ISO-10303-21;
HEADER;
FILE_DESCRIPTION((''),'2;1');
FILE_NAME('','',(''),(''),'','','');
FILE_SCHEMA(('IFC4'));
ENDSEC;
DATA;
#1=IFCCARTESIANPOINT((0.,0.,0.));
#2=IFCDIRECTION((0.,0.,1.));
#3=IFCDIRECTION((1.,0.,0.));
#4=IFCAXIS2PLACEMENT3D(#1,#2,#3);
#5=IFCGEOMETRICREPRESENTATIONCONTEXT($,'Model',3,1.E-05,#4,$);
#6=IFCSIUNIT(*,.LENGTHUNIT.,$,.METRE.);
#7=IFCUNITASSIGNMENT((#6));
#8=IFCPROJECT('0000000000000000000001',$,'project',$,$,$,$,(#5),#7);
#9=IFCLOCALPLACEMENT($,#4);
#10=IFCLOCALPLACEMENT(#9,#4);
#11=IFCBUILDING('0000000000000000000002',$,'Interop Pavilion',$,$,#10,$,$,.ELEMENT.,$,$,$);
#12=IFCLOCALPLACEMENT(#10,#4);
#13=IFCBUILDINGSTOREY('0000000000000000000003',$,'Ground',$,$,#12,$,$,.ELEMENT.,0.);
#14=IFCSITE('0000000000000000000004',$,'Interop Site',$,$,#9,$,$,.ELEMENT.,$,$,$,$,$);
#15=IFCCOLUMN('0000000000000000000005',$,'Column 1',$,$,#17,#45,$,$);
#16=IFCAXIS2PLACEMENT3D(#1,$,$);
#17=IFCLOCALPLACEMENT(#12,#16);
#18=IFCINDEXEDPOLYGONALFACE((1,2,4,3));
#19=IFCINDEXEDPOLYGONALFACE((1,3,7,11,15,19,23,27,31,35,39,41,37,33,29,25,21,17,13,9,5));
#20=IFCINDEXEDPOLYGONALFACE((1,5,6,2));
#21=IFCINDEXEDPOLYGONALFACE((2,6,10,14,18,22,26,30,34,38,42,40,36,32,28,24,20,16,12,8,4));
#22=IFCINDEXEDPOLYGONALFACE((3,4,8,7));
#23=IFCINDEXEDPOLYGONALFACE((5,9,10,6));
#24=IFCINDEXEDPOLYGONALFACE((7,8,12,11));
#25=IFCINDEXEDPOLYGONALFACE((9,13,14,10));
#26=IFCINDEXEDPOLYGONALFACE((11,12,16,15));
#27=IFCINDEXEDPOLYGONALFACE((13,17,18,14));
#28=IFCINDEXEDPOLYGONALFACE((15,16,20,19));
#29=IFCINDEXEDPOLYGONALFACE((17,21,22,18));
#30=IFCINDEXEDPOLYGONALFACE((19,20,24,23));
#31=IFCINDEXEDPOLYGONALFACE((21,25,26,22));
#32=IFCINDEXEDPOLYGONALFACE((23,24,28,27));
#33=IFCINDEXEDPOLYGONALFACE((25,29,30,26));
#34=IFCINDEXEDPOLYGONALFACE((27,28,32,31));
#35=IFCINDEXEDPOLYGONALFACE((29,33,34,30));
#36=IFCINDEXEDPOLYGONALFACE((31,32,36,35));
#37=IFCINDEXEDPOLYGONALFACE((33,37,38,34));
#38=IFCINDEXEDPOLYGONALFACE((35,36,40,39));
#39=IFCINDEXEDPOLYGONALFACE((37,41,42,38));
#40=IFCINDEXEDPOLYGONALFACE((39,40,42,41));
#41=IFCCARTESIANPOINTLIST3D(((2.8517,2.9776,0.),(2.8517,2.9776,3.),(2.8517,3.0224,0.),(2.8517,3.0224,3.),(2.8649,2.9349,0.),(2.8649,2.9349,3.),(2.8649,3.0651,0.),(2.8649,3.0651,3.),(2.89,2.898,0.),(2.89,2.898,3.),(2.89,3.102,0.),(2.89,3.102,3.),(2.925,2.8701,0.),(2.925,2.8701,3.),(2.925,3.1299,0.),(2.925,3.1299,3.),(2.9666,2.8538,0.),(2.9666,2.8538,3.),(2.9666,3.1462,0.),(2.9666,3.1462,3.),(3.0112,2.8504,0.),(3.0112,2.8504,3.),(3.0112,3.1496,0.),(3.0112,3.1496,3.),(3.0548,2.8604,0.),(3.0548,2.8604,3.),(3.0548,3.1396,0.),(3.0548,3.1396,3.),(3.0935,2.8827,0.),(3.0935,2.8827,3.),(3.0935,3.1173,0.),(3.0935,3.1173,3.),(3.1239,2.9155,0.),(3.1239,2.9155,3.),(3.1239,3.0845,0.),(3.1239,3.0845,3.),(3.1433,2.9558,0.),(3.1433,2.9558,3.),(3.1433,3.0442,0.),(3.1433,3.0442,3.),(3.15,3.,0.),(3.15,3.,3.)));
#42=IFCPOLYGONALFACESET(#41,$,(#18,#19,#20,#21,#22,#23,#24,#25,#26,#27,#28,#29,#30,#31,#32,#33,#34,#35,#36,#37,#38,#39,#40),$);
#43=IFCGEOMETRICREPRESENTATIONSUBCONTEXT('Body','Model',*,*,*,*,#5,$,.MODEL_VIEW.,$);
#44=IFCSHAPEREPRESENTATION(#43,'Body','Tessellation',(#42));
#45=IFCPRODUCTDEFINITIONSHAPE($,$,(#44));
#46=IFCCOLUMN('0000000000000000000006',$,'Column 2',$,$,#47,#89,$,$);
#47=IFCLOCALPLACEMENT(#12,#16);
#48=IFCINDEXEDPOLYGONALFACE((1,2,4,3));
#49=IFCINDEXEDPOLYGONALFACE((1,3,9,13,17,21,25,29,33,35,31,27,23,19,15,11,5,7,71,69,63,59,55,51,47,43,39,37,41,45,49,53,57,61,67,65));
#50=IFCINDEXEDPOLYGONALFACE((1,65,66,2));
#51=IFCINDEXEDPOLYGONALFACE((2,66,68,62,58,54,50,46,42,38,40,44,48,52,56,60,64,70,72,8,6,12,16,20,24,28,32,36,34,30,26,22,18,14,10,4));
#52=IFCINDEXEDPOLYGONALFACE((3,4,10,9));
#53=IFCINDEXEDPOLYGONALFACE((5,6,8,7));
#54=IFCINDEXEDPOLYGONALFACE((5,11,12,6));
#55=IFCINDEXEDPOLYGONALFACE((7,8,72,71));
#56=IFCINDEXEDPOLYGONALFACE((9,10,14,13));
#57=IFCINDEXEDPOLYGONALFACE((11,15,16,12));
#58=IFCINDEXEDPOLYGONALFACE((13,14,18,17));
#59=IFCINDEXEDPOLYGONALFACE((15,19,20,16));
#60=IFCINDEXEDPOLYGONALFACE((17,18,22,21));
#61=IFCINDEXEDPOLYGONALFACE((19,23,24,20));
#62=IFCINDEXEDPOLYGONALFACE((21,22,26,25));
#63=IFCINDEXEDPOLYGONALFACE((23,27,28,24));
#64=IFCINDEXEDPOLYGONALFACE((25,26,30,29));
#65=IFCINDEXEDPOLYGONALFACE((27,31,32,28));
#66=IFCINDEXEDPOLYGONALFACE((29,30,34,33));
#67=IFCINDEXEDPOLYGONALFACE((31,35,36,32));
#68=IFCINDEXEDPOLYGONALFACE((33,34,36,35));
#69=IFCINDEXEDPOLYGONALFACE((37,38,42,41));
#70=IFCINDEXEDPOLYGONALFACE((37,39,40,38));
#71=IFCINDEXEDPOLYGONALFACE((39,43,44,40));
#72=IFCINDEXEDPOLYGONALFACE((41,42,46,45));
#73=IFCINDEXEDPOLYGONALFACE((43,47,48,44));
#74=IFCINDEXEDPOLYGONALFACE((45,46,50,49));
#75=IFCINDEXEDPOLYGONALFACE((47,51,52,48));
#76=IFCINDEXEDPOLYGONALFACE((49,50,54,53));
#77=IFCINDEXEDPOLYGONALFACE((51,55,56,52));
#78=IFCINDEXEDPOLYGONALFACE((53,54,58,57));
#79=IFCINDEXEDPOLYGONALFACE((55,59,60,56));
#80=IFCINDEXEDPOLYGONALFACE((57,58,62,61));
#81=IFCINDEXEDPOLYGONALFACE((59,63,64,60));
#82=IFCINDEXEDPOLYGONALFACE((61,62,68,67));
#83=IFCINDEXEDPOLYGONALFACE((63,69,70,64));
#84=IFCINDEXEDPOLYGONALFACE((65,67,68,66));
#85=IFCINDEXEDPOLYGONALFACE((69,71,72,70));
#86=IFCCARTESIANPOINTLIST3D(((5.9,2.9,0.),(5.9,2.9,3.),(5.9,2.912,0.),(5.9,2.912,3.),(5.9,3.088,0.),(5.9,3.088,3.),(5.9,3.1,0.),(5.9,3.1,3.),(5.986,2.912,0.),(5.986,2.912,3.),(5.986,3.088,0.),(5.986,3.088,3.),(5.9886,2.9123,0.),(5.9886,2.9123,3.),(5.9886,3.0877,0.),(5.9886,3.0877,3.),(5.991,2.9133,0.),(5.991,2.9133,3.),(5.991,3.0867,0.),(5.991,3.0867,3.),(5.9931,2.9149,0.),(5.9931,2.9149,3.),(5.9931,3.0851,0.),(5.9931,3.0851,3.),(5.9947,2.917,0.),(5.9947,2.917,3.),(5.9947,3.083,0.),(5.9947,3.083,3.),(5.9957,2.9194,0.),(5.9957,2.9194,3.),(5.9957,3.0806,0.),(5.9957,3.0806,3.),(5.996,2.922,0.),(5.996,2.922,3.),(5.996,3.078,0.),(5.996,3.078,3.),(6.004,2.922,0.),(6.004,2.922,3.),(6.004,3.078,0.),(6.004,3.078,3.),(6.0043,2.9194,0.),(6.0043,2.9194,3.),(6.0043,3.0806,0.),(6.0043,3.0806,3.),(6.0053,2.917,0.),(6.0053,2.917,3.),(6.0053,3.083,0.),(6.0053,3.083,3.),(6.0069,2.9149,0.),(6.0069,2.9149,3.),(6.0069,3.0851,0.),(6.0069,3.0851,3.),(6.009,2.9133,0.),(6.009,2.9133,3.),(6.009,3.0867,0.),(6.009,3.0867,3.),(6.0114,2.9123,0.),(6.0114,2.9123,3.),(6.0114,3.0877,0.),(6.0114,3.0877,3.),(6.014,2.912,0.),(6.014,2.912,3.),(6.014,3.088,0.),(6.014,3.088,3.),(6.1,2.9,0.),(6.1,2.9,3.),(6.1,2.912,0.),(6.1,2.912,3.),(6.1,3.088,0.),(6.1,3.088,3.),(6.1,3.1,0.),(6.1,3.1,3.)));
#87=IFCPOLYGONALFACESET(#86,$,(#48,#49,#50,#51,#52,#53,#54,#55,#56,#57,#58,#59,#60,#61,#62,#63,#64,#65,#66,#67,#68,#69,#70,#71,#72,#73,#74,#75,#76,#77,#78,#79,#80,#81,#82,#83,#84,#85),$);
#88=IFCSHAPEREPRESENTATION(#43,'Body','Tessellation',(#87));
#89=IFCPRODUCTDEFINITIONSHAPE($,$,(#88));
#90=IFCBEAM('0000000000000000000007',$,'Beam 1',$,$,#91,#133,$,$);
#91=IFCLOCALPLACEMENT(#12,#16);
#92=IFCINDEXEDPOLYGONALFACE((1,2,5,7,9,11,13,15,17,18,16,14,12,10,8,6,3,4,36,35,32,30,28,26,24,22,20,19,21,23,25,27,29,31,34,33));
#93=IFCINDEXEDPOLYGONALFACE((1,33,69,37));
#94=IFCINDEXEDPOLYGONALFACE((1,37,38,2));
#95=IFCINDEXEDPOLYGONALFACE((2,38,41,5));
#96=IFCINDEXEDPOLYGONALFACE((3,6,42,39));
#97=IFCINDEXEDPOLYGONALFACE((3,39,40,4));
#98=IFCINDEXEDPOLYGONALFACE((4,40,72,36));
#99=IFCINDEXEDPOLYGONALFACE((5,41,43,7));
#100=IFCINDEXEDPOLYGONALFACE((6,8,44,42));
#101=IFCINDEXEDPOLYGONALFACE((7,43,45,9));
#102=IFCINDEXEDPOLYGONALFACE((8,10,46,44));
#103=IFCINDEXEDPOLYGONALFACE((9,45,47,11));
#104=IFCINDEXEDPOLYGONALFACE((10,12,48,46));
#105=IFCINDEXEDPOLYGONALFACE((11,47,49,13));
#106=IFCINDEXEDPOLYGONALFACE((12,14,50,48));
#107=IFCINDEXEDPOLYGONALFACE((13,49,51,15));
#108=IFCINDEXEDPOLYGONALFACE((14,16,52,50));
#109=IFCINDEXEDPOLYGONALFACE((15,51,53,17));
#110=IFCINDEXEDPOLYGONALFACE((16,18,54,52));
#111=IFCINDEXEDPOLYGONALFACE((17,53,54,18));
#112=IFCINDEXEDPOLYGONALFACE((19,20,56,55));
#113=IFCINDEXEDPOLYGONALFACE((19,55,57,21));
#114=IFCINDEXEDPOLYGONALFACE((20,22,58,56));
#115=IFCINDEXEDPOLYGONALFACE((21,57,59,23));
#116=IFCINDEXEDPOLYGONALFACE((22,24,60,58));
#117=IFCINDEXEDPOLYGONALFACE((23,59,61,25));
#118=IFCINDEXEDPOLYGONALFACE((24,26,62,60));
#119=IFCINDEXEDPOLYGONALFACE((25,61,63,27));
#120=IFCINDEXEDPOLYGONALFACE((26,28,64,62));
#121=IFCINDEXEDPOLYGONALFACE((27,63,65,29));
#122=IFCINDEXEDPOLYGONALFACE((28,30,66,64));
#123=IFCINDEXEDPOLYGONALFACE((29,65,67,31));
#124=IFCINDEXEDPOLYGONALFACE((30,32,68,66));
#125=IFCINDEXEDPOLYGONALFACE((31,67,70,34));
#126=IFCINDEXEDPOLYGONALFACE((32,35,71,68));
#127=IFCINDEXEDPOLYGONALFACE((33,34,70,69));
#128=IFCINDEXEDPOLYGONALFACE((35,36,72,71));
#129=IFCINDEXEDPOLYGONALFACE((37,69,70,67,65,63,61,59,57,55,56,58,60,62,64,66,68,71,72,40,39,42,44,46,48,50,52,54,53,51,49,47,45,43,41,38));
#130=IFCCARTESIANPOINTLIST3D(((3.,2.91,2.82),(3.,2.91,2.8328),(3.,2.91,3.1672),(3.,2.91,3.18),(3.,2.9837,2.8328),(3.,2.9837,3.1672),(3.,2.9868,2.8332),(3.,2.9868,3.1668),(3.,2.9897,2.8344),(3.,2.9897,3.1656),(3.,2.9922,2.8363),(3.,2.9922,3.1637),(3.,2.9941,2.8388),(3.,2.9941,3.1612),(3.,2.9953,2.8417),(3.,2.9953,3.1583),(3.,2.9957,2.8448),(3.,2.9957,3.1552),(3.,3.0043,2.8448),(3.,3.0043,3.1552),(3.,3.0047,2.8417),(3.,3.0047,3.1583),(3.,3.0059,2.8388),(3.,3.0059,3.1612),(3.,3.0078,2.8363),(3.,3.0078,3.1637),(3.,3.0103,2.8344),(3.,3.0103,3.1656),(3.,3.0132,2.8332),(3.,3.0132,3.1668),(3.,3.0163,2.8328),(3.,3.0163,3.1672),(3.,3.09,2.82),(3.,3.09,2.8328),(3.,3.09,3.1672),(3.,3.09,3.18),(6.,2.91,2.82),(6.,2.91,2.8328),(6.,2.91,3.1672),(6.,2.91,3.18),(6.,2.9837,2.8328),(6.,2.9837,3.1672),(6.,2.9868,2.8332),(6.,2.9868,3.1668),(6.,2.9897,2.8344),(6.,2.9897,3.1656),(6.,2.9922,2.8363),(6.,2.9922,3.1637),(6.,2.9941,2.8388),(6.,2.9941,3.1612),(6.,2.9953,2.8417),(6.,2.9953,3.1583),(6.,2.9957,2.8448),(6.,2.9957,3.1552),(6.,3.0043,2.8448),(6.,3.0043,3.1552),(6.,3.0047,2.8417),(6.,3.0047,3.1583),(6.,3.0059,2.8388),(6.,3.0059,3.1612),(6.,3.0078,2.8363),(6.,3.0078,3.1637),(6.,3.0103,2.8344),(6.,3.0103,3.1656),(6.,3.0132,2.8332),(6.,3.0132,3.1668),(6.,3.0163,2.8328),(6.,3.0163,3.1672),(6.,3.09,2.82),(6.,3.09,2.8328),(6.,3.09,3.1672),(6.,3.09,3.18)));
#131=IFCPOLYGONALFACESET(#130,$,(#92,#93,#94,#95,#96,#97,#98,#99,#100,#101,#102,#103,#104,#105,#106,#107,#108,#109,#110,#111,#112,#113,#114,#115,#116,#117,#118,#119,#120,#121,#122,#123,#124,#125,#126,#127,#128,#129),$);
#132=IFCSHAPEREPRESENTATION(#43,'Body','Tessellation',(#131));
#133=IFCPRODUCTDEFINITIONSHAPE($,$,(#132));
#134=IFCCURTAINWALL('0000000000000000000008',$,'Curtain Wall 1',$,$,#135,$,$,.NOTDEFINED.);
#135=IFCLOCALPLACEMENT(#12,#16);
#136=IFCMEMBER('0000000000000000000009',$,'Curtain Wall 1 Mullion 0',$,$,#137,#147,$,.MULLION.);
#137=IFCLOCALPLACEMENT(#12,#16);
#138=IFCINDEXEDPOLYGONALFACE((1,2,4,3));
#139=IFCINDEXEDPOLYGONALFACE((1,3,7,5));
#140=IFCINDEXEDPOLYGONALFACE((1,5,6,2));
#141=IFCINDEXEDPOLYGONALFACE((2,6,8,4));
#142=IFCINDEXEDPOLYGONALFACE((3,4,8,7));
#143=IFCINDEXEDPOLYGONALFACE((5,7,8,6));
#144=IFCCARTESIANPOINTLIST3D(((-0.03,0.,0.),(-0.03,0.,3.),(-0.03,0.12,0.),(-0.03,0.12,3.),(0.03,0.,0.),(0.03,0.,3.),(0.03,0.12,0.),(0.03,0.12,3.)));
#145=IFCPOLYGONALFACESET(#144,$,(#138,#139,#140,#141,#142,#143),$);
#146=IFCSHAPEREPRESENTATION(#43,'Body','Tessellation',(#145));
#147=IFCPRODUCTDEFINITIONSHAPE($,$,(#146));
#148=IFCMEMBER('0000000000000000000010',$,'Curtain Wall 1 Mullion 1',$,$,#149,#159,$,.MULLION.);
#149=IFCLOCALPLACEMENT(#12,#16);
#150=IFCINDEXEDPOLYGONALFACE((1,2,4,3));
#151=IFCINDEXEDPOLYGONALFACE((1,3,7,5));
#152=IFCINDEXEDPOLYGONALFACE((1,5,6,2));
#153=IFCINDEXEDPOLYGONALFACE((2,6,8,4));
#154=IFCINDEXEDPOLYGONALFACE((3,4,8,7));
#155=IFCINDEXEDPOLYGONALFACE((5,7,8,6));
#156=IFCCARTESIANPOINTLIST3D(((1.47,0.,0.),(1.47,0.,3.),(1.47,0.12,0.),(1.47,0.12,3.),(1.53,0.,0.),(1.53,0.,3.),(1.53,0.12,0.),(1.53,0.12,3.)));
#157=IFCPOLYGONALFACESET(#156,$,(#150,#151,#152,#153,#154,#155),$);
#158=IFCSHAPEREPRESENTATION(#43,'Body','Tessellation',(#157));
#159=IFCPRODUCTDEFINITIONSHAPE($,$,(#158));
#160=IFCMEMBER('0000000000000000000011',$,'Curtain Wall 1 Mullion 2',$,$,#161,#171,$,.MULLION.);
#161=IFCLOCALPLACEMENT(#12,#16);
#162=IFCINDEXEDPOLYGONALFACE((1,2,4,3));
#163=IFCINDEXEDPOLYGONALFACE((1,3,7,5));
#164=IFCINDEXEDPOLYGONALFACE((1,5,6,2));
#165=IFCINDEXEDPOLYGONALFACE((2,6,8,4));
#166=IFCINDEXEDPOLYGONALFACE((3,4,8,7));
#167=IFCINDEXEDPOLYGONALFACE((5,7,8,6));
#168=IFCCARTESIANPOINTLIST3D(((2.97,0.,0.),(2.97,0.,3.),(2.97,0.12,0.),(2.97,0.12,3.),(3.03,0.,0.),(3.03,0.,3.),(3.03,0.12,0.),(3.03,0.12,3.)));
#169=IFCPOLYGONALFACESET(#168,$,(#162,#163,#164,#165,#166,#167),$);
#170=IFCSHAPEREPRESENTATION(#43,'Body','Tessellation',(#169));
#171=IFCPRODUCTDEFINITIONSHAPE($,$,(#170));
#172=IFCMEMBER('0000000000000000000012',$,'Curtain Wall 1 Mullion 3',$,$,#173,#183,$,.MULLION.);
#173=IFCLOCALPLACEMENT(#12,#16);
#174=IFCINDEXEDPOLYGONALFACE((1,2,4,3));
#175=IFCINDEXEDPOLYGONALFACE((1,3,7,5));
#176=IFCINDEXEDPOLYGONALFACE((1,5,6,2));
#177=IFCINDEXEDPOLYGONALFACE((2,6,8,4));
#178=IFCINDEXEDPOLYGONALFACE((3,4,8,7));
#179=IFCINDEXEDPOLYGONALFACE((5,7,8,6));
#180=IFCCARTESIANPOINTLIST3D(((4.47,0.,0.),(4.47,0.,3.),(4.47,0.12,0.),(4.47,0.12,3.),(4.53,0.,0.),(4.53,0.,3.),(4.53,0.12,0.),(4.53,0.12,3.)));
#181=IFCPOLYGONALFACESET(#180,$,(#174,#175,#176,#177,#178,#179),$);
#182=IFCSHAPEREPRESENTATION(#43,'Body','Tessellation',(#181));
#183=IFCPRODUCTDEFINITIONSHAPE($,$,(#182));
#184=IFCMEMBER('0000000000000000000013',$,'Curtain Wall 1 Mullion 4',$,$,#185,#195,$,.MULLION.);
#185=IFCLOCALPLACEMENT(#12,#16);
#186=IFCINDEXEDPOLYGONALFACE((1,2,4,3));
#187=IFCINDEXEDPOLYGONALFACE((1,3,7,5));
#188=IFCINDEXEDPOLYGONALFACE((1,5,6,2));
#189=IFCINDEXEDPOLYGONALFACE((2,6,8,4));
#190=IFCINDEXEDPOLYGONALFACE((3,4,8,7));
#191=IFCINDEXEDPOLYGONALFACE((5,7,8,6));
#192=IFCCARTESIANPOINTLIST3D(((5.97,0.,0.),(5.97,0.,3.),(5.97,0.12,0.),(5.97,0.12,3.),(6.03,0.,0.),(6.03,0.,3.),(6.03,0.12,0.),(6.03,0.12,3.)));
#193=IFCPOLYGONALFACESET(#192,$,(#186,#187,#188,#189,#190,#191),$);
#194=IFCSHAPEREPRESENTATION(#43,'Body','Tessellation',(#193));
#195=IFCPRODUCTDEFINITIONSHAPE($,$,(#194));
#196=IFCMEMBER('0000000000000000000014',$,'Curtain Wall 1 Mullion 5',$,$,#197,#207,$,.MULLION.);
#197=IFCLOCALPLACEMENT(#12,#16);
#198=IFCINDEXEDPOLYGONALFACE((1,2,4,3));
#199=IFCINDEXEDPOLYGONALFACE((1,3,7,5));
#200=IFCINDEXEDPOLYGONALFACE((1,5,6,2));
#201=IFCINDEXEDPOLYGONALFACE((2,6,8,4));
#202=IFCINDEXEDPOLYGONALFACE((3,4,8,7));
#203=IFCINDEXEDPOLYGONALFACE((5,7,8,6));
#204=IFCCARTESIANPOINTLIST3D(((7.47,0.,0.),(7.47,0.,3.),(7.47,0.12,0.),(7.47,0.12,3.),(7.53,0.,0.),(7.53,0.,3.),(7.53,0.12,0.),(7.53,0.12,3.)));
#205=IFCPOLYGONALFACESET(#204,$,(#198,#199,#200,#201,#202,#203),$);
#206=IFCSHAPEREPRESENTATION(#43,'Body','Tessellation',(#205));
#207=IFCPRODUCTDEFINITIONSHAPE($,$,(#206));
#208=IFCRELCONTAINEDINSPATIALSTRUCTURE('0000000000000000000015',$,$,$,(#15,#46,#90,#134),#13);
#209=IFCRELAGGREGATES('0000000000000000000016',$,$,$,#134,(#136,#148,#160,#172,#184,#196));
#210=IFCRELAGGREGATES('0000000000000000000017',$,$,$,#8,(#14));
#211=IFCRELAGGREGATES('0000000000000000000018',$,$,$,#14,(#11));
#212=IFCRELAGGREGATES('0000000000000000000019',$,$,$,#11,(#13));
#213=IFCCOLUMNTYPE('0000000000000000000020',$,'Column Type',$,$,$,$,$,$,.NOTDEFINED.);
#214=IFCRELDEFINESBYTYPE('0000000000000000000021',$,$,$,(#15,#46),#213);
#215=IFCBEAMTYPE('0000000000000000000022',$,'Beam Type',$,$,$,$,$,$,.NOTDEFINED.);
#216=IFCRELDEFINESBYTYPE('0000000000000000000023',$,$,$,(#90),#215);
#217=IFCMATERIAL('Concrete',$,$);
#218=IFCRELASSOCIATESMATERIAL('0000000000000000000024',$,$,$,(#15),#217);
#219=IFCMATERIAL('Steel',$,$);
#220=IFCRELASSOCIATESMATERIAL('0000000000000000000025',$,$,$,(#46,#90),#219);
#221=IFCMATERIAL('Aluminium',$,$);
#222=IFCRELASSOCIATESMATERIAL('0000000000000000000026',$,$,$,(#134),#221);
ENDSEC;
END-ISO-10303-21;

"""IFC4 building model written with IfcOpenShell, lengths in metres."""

from ifc_helpers import new_model, si_unit, frame, frame_2d, origin_with_axes, origin_2d, place, context, subcontext, project, spatial, rectangle, circle, i_section, extrude, material, type_object, element, aggregate, save


model = new_model("IFC4")

# Units and contexts
model_context = context("Model", 3, precision=1e-05, world=origin_with_axes())
body_context = subcontext(model_context, "Body", "Model", "MODEL_VIEW")
ifc_project = project(units=[si_unit("LENGTHUNIT", "METRE")], contexts=[model_context])

# Site, building, storey
site_placement = place(None, origin_with_axes())
site = spatial("IfcSite", under=ifc_project, at=site_placement, Name="Interop Site", CompositionType="ELEMENT")
building_placement = place(site_placement, origin_with_axes())
building = spatial("IfcBuilding", under=site, at=building_placement, Name="Interop Pavilion", CompositionType="ELEMENT")
storey_placement = place(building_placement, origin_with_axes())
storey = spatial("IfcBuildingStorey", under=building, at=storey_placement, Name="Ground", CompositionType="ELEMENT", Elevation=0.0)

# Columns
ifc_material_1 = material(Name="Concrete")
column_type = type_object("IfcColumnType", Name="Column Type", PredefinedType="NOTDEFINED")
column_1_placement = place(storey_placement, frame((3.0, 3.0, 0.0), z_axis=(0.0, 0.0, 1.0), x_axis=(1.0, 0.0, 0.0)))
element("IfcColumn", 1, at=column_1_placement, inside=storey, type_object=column_type, material=ifc_material_1, Name="Column 1", context=body_context, shape_type="SweptSolid", body=[
    extrude(circle(Radius=0.15, at=origin_2d()), origin_with_axes(), (0.0, 0.0, 1.0), 3.0),
])
ifc_material_2 = material(Name="Steel")
column_2_placement = place(storey_placement, frame((6.0, 3.0, 0.0), z_axis=(0.0, 0.0, 1.0), x_axis=(1.0, 0.0, 0.0)))
element("IfcColumn", 2, at=column_2_placement, inside=storey, type_object=column_type, material=ifc_material_2, Name="Column 2", context=body_context, shape_type="SweptSolid", body=[
    extrude(i_section(OverallWidth=0.2, OverallDepth=0.2, WebThickness=0.008, FlangeThickness=0.012, FilletRadius=0.01, at=origin_2d()), origin_with_axes(), (0.0, 0.0, 1.0), 3.0),
])

# Beam
beam_type = type_object("IfcBeamType", Name="Beam Type", PredefinedType="NOTDEFINED")
beam_placement = place(storey_placement, frame((3.0, 3.0, 3.0), z_axis=(1.0, 0.0, 0.0), x_axis=(0.0, 1.0, 0.0)))
element("IfcBeam", 3, at=beam_placement, inside=storey, type_object=beam_type, material=ifc_material_2, Name="Beam 1", context=body_context, shape_type="SweptSolid", body=[
    extrude(i_section(OverallWidth=0.18, OverallDepth=0.36, WebThickness=0.0086, FlangeThickness=0.0128, FilletRadius=0.012, at=origin_2d()), origin_with_axes(), (0.0, 0.0, 1.0), 3.0),
])

# Curtain wall, members
ifc_material_3 = material(Name="Aluminium")
curtain_wall_placement = place(storey_placement, origin_with_axes())
curtain_wall = element("IfcCurtainWall", 4, at=curtain_wall_placement, inside=storey, material=ifc_material_3, Name="Curtain Wall 1", PredefinedType="NOTDEFINED")
member_1_placement = place(curtain_wall_placement, frame((-0.03, 0.0, 0.0), z_axis=(0.0, 0.0, 1.0), x_axis=(1.0, 0.0, 0.0)))
member_1 = element("IfcMember", 5, at=member_1_placement, Name="Curtain Wall 1 Mullion 0", PredefinedType="MULLION", context=body_context, shape_type="SweptSolid", body=[
    extrude(rectangle(XDim=0.06, YDim=0.12, at=frame_2d((0.03, 0.06))), origin_with_axes(), (0.0, 0.0, 1.0), 3.0),
])
member_2_placement = place(curtain_wall_placement, frame((1.47, 0.0, 0.0), z_axis=(0.0, 0.0, 1.0), x_axis=(1.0, 0.0, 0.0)))
member_2 = element("IfcMember", 6, at=member_2_placement, Name="Curtain Wall 1 Mullion 1", PredefinedType="MULLION", context=body_context, shape_type="SweptSolid", body=[
    extrude(rectangle(XDim=0.06, YDim=0.12, at=frame_2d((0.03, 0.06))), origin_with_axes(), (0.0, 0.0, 1.0), 3.0),
])
member_3_placement = place(curtain_wall_placement, frame((2.97, 0.0, 0.0), z_axis=(0.0, 0.0, 1.0), x_axis=(1.0, 0.0, 0.0)))
member_3 = element("IfcMember", 7, at=member_3_placement, Name="Curtain Wall 1 Mullion 2", PredefinedType="MULLION", context=body_context, shape_type="SweptSolid", body=[
    extrude(rectangle(XDim=0.06, YDim=0.12, at=frame_2d((0.03, 0.06))), origin_with_axes(), (0.0, 0.0, 1.0), 3.0),
])
member_4_placement = place(curtain_wall_placement, frame((4.47, 0.0, 0.0), z_axis=(0.0, 0.0, 1.0), x_axis=(1.0, 0.0, 0.0)))
member_4 = element("IfcMember", 8, at=member_4_placement, Name="Curtain Wall 1 Mullion 3", PredefinedType="MULLION", context=body_context, shape_type="SweptSolid", body=[
    extrude(rectangle(XDim=0.06, YDim=0.12, at=frame_2d((0.03, 0.06))), origin_with_axes(), (0.0, 0.0, 1.0), 3.0),
])
member_5_placement = place(curtain_wall_placement, frame((5.97, 0.0, 0.0), z_axis=(0.0, 0.0, 1.0), x_axis=(1.0, 0.0, 0.0)))
member_5 = element("IfcMember", 9, at=member_5_placement, Name="Curtain Wall 1 Mullion 4", PredefinedType="MULLION", context=body_context, shape_type="SweptSolid", body=[
    extrude(rectangle(XDim=0.06, YDim=0.12, at=frame_2d((0.03, 0.06))), origin_with_axes(), (0.0, 0.0, 1.0), 3.0),
])
member_6_placement = place(curtain_wall_placement, frame((7.47, 0.0, 0.0), z_axis=(0.0, 0.0, 1.0), x_axis=(1.0, 0.0, 0.0)))
member_6 = element("IfcMember", 10, at=member_6_placement, Name="Curtain Wall 1 Mullion 5", PredefinedType="MULLION", context=body_context, shape_type="SweptSolid", body=[
    extrude(rectangle(XDim=0.06, YDim=0.12, at=frame_2d((0.03, 0.06))), origin_with_axes(), (0.0, 0.0, 1.0), 3.0),
])

aggregate(curtain_wall, [member_1, member_2, member_3, member_4, member_5, member_6])

save(model, "model.ifc")
